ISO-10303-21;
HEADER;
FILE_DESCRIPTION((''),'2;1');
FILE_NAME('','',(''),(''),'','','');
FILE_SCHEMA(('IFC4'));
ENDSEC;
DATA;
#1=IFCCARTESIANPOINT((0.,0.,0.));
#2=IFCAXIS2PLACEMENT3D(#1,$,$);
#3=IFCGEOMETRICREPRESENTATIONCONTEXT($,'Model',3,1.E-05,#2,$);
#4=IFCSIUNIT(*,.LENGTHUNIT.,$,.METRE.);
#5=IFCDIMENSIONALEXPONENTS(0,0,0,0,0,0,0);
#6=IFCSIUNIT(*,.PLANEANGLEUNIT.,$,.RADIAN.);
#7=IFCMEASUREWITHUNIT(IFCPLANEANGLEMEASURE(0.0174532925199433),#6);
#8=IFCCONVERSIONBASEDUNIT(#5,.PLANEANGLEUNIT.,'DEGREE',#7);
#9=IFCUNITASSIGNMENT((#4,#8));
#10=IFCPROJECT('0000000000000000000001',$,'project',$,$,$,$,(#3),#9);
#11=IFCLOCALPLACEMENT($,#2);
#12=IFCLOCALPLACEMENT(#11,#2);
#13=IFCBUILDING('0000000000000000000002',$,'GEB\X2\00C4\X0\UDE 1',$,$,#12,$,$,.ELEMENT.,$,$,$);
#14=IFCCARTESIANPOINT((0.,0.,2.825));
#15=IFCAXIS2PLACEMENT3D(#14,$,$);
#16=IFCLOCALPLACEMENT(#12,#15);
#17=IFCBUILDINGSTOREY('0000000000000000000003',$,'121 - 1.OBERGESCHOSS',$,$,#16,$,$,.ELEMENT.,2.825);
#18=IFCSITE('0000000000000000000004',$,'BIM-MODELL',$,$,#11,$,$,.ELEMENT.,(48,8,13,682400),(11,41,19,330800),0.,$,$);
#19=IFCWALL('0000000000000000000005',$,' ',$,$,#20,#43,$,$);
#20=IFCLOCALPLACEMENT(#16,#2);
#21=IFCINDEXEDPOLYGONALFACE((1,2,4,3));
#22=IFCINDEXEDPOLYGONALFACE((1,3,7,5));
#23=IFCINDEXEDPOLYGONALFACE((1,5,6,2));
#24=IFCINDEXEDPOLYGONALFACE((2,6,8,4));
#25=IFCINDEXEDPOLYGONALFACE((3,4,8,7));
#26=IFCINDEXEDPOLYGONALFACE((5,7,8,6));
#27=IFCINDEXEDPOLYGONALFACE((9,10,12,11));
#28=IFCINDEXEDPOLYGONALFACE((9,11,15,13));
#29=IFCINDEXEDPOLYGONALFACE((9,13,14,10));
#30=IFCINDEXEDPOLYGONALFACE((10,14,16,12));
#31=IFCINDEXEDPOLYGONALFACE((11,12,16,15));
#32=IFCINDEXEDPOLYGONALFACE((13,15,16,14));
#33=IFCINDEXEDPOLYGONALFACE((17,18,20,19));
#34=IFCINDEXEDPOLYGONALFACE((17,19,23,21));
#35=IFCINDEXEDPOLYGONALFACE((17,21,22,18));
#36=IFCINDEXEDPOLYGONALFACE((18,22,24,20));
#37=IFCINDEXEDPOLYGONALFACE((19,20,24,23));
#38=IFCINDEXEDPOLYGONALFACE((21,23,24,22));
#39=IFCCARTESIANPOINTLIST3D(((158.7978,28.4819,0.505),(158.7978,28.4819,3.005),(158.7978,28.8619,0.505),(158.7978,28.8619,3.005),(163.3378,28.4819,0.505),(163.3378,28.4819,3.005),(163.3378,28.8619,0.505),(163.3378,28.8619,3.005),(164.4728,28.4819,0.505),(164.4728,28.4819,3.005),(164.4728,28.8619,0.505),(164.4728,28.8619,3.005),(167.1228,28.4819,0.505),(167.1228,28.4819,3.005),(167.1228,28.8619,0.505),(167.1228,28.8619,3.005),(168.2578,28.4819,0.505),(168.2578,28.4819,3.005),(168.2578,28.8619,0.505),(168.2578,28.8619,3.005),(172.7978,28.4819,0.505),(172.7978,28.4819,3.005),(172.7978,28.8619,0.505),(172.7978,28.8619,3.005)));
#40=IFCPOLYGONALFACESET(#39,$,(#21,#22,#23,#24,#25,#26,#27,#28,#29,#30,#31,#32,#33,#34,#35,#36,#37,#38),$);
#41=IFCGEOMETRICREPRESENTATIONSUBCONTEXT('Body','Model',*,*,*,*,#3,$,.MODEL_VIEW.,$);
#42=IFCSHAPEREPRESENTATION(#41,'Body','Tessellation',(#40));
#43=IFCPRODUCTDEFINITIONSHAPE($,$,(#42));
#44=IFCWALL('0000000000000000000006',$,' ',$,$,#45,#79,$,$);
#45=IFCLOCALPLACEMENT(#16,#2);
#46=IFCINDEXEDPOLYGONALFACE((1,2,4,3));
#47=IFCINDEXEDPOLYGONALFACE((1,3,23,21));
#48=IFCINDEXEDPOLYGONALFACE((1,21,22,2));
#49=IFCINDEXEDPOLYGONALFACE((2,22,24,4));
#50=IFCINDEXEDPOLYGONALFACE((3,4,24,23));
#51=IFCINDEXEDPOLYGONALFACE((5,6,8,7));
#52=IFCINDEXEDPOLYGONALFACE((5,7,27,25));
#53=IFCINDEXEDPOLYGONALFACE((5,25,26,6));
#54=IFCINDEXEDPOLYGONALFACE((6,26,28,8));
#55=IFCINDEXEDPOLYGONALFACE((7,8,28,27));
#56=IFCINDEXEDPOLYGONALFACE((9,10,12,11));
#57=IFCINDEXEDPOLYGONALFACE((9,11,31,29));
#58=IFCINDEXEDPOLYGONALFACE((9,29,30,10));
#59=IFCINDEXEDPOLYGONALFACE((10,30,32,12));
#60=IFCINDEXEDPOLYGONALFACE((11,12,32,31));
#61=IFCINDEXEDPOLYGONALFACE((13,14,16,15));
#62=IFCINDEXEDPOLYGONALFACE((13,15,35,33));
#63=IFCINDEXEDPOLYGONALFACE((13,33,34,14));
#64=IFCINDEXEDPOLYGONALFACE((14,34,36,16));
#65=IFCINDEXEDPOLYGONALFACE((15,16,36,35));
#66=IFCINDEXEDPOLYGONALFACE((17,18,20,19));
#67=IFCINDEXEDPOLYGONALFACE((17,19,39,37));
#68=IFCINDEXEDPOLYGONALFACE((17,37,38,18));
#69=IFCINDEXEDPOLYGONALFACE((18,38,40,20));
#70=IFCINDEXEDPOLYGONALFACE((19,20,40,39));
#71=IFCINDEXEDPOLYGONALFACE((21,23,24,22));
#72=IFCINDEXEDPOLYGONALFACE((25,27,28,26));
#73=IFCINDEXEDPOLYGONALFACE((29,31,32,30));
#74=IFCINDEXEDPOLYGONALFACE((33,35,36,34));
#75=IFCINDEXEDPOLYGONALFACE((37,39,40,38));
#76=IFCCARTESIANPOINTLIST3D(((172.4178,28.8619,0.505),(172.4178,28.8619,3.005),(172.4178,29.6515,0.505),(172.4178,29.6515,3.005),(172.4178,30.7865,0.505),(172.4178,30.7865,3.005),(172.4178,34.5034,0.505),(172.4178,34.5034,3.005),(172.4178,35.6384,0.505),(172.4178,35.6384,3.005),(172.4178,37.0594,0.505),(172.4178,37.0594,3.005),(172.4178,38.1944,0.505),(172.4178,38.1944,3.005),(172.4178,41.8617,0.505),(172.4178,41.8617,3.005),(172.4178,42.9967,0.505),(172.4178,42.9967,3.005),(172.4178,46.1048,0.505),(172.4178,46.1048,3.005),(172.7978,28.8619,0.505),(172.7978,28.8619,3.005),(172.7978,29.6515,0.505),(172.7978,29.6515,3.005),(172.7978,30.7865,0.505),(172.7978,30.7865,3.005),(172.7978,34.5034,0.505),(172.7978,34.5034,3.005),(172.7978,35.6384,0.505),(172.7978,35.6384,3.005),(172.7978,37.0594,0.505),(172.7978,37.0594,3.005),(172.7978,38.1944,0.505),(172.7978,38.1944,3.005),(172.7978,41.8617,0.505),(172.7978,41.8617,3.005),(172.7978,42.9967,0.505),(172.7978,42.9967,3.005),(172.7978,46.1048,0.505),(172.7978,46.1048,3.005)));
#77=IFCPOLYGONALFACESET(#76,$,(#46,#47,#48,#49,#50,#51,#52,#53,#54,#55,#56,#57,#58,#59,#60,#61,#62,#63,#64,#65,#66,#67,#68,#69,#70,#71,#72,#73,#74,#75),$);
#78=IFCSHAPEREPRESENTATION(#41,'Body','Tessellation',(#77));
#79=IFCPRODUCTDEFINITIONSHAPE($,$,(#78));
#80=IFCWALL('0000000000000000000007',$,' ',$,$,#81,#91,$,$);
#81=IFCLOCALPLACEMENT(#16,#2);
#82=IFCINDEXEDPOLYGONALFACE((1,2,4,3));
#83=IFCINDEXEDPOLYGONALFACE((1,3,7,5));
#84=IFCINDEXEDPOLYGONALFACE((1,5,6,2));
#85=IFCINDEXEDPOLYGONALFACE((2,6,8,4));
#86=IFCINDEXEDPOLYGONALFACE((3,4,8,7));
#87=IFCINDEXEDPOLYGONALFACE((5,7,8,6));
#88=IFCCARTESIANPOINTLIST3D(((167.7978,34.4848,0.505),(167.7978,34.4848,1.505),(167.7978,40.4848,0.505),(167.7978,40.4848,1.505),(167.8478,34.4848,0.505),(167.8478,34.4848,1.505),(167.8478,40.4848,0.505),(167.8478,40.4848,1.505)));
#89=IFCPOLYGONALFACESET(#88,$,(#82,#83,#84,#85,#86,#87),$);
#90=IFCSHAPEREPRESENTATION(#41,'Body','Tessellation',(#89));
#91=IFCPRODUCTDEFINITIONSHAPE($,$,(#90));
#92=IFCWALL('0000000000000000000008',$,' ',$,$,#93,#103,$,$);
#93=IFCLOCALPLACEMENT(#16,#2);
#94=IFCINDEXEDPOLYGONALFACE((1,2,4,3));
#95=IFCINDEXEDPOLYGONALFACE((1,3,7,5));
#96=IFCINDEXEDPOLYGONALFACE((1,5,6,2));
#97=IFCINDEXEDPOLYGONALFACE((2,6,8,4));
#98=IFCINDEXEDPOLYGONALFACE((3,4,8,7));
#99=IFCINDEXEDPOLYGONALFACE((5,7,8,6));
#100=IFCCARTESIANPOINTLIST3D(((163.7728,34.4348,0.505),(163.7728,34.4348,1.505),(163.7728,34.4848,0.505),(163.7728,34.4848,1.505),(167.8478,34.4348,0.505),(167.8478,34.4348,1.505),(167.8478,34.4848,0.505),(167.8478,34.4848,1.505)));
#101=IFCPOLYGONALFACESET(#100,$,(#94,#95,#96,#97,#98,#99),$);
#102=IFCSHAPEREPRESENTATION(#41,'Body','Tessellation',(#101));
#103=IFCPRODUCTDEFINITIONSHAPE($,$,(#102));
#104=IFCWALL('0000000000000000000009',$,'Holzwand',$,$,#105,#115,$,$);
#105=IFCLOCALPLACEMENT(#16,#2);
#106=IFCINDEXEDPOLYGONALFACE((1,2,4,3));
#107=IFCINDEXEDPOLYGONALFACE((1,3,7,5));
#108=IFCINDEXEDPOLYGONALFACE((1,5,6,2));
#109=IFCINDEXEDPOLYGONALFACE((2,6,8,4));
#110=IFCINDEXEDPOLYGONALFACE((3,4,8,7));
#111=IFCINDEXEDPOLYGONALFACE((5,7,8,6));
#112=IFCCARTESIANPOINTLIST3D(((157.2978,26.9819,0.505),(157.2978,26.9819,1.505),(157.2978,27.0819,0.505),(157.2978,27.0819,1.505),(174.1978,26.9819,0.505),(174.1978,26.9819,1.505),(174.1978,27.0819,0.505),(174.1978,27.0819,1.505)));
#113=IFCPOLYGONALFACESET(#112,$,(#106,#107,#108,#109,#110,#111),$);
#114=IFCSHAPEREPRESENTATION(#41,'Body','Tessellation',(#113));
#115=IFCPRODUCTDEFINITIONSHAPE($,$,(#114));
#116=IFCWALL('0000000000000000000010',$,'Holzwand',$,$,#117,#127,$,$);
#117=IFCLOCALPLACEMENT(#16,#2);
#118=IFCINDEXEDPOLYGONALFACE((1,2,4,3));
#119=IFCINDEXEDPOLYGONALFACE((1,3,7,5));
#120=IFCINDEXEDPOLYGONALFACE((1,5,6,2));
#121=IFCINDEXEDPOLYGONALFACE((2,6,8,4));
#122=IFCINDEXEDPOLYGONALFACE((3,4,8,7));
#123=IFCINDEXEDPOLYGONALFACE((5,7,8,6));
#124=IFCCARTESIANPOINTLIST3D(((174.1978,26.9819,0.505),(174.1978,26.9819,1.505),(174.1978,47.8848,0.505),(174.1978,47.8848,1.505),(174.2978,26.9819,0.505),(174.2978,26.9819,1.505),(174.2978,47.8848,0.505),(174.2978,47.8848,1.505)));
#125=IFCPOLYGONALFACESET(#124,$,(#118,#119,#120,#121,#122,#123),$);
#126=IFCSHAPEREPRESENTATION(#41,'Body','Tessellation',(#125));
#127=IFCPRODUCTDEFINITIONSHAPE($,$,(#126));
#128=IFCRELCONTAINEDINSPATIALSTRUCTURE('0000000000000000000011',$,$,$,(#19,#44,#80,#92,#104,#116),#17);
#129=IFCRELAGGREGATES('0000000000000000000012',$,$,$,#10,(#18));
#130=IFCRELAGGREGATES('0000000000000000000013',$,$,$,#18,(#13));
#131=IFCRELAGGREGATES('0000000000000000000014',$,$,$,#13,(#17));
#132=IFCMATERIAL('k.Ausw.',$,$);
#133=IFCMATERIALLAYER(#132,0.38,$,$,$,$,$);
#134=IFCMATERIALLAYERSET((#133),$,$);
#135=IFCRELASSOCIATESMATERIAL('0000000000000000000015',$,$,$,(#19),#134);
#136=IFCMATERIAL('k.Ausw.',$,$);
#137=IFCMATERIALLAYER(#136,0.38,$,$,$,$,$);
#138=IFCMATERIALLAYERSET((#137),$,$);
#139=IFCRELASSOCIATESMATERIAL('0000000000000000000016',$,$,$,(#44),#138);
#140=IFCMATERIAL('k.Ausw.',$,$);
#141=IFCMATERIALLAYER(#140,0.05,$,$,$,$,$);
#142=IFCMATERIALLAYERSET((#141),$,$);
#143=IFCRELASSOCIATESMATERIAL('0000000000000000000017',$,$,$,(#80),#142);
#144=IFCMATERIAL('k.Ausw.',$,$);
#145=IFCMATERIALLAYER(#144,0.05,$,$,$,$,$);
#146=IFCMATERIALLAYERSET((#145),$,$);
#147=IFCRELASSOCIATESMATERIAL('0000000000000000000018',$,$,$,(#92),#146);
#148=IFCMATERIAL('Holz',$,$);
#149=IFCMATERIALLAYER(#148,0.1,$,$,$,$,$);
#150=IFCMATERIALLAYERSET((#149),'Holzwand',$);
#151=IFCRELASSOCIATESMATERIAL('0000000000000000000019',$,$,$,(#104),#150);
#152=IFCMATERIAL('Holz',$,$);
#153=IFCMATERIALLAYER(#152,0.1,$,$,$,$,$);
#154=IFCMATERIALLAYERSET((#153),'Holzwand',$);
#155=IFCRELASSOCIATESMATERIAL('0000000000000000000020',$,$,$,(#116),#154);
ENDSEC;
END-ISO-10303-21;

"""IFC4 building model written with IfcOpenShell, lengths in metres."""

from ifc_helpers import new_model, entity, si_unit, converted_unit, frame, frame_2d, origin, origin_with_axes, place, context, subcontext, project, spatial, polyline, rectangle, outline, extrude, material, layer, layer_set, layer_usage, element, save


model = new_model("IFC4")

# Units and contexts
model_context = context("Model", 3, precision=1e-05, world=origin())
body_context = subcontext(model_context, "Body", "Model", "MODEL_VIEW")
ifc_project = project(units=[si_unit("LENGTHUNIT", "METRE"), converted_unit("PLANEANGLEUNIT", "DEGREE", entity("IfcPlaneAngleMeasure", 0.0174532925199433), si_unit("PLANEANGLEUNIT", "RADIAN"), dimensions=[0, 0, 0, 0, 0, 0, 0])], contexts=[model_context])

# Site, building, storey
site_placement = place(None, origin())
site = spatial("IfcSite", under=ifc_project, at=site_placement, Name="BIM-MODELL", CompositionType="ELEMENT", RefLatitude=(48, 8, 13, 682400), RefLongitude=(11, 41, 19, 330800), RefElevation=0.0)
building_placement = place(site_placement, origin())
building = spatial("IfcBuilding", under=site, at=building_placement, Name="GEBÄUDE 1", CompositionType="ELEMENT")
storey_placement = place(building_placement, frame((0.0, 0.0, 2.825)))
storey = spatial("IfcBuildingStorey", under=building, at=storey_placement, Name="121 - 1.OBERGESCHOSS", CompositionType="ELEMENT", Elevation=2.825)

# Walls, openings
ifc_material_1 = material(Name="k.Ausw.")
ifc_layer_1 = layer(ifc_material_1, 0.38)
ifc_layer_set_1 = layer_set([ifc_layer_1])
ifc_layer_usage_1 = layer_usage(ifc_layer_set_1, "AXIS2", "POSITIVE", 0.0)
wall_1_placement = place(storey_placement, frame((158.7978, 28.4819, 0.505), z_axis=(0.0, 0.0, 1.0), x_axis=(1.0, 0.0, 0.0)))
wall_1 = element("IfcWall", 1, at=wall_1_placement, inside=storey, material=ifc_layer_usage_1, Name=" ", context=body_context, shape_type="SweptSolid", body=[
    extrude(rectangle(XDim=14.0, YDim=0.38, at=frame_2d((7.0, 0.19), x_axis=(1.0, 0.0))), origin_with_axes(), (0.0, 0.0, 1.0), 2.5),
])
opening_1_placement = place(wall_1_placement, frame((5.675, 0.38, 0.0), z_axis=(0.0, -1.0, 0.0), x_axis=(0.0, 0.0, 1.0)))
element("IfcOpeningElement", 2, at=opening_1_placement, cuts=wall_1, ObjectType="Opening", context=body_context, shape_type="SweptSolid", body=[
    extrude(outline(polyline([(0.0, 1.135), (2.5, 1.135), (2.5, 0.0), (0.0, 0.0), (0.0, 1.135)])), origin_with_axes(), (0.0, 0.0, 1.0), 0.38),
])
opening_2_placement = place(wall_1_placement, frame((9.46, 0.38, 0.0), z_axis=(0.0, -1.0, 0.0), x_axis=(0.0, 0.0, 1.0)))
element("IfcOpeningElement", 3, at=opening_2_placement, cuts=wall_1, ObjectType="Opening", context=body_context, shape_type="SweptSolid", body=[
    extrude(outline(polyline([(0.0, 1.135), (2.5, 1.135), (2.5, 0.0), (0.0, 0.0), (0.0, 1.135)])), origin_with_axes(), (0.0, 0.0, 1.0), 0.38),
])
ifc_material_2 = material(Name="k.Ausw.")
ifc_layer_2 = layer(ifc_material_2, 0.38)
ifc_layer_set_2 = layer_set([ifc_layer_2])
ifc_layer_usage_2 = layer_usage(ifc_layer_set_2, "AXIS2", "POSITIVE", 0.0)
wall_2_placement = place(storey_placement, frame((172.7978, 28.8619, 0.505), z_axis=(0.0, 0.0, 1.0), x_axis=(0.0, 1.0, 0.0)))
wall_2 = element("IfcWall", 4, at=wall_2_placement, inside=storey, material=ifc_layer_usage_2, Name=" ", context=body_context, shape_type="SweptSolid", body=[
    extrude(rectangle(XDim=17.2429, YDim=0.38, at=frame_2d((8.6214, 0.19), x_axis=(1.0, 0.0))), origin_with_axes(), (0.0, 0.0, 1.0), 2.5),
])
opening_3_placement = place(wall_2_placement, frame((1.9246, 0.38, 0.0), z_axis=(0.0, -1.0, 0.0), x_axis=(0.0, 0.0, 1.0)))
element("IfcOpeningElement", 5, at=opening_3_placement, cuts=wall_2, ObjectType="Opening", context=body_context, shape_type="SweptSolid", body=[
    extrude(outline(polyline([(0.0, 1.135), (2.5, 1.135), (2.5, 0.0), (0.0, 0.0), (0.0, 1.135)])), origin_with_axes(), (0.0, 0.0, 1.0), 0.38),
])
opening_4_placement = place(wall_2_placement, frame((9.3325, 0.38, 0.0), z_axis=(0.0, -1.0, 0.0), x_axis=(0.0, 0.0, 1.0)))
element("IfcOpeningElement", 6, at=opening_4_placement, cuts=wall_2, ObjectType="Opening", context=body_context, shape_type="SweptSolid", body=[
    extrude(outline(polyline([(0.0, 1.135), (2.5, 1.135), (2.5, 0.0), (0.0, 0.0), (0.0, 1.135)])), origin_with_axes(), (0.0, 0.0, 1.0), 0.38),
])
opening_5_placement = place(wall_2_placement, frame((6.7764, 0.38, 0.0), z_axis=(0.0, -1.0, 0.0), x_axis=(0.0, 0.0, 1.0)))
element("IfcOpeningElement", 7, at=opening_5_placement, cuts=wall_2, ObjectType="Opening", context=body_context, shape_type="SweptSolid", body=[
    extrude(outline(polyline([(0.0, 1.135), (2.5, 1.135), (2.5, 0.0), (0.0, 0.0), (0.0, 1.135)])), origin_with_axes(), (0.0, 0.0, 1.0), 0.38),
])
opening_6_placement = place(wall_2_placement, frame((14.1348, 0.38, 0.0), z_axis=(0.0, -1.0, 0.0), x_axis=(0.0, 0.0, 1.0)))
element("IfcOpeningElement", 8, at=opening_6_placement, cuts=wall_2, ObjectType="Opening", context=body_context, shape_type="SweptSolid", body=[
    extrude(outline(polyline([(0.0, 1.135), (2.5, 1.135), (2.5, 0.0), (0.0, 0.0), (0.0, 1.135)])), origin_with_axes(), (0.0, 0.0, 1.0), 0.38),
])

# Walls
ifc_material_3 = material(Name="k.Ausw.")
ifc_layer_3 = layer(ifc_material_3, 0.05)
ifc_layer_set_3 = layer_set([ifc_layer_3])
ifc_layer_usage_3 = layer_usage(ifc_layer_set_3, "AXIS2", "POSITIVE", 0.0)
wall_3_placement = place(storey_placement, frame((167.8478, 34.4848, 0.505), z_axis=(0.0, 0.0, 1.0), x_axis=(0.0, 1.0, 0.0)))
element("IfcWall", 9, at=wall_3_placement, inside=storey, material=ifc_layer_usage_3, Name=" ", context=body_context, shape_type="SweptSolid", body=[
    extrude(rectangle(XDim=6.0, YDim=0.05, at=frame_2d((3.0, 0.025), x_axis=(1.0, 0.0))), origin_with_axes(), (0.0, 0.0, 1.0), 1.0),
])
ifc_material_4 = material(Name="k.Ausw.")
ifc_layer_4 = layer(ifc_material_4, 0.05)
ifc_layer_set_4 = layer_set([ifc_layer_4])
ifc_layer_usage_4 = layer_usage(ifc_layer_set_4, "AXIS2", "POSITIVE", 0.0)
wall_4_placement = place(storey_placement, frame((163.7728, 34.4348, 0.505), z_axis=(0.0, 0.0, 1.0), x_axis=(1.0, 0.0, 0.0)))
element("IfcWall", 10, at=wall_4_placement, inside=storey, material=ifc_layer_usage_4, Name=" ", context=body_context, shape_type="SweptSolid", body=[
    extrude(rectangle(XDim=4.075, YDim=0.05, at=frame_2d((2.0375, 0.025), x_axis=(1.0, 0.0))), origin_with_axes(), (0.0, 0.0, 1.0), 1.0),
])
ifc_material_5 = material(Name="Holz")
ifc_layer_5 = layer(ifc_material_5, 0.1)
ifc_layer_set_5 = layer_set([ifc_layer_5], Name="Holzwand")
ifc_layer_usage_5 = layer_usage(ifc_layer_set_5, "AXIS2", "POSITIVE", 0.0)
wall_5_placement = place(storey_placement, frame((157.2978, 26.9819, 0.505)))
element("IfcWall", 11, at=wall_5_placement, inside=storey, material=ifc_layer_usage_5, Name="Holzwand", context=body_context, shape_type="SweptSolid", body=[
    extrude(rectangle(XDim=16.9, YDim=0.1, at=frame_2d((8.45, 0.05), x_axis=(1.0, 0.0))), origin_with_axes(), (0.0, 0.0, 1.0), 1.0),
])
ifc_material_6 = material(Name="Holz")
ifc_layer_6 = layer(ifc_material_6, 0.1)
ifc_layer_set_6 = layer_set([ifc_layer_6], Name="Holzwand")
ifc_layer_usage_6 = layer_usage(ifc_layer_set_6, "AXIS2", "POSITIVE", 0.0)
wall_6_placement = place(storey_placement, frame((174.2978, 26.9819, 0.505), z_axis=(0.0, 0.0, 1.0), x_axis=(0.0, 1.0, 0.0)))
element("IfcWall", 12, at=wall_6_placement, inside=storey, material=ifc_layer_usage_6, Name="Holzwand", context=body_context, shape_type="SweptSolid", body=[
    extrude(rectangle(XDim=20.9029, YDim=0.1, at=frame_2d((10.4514, 0.05), x_axis=(1.0, 0.0))), origin_with_axes(), (0.0, 0.0, 1.0), 1.0),
])

save(model, "model.ifc")
